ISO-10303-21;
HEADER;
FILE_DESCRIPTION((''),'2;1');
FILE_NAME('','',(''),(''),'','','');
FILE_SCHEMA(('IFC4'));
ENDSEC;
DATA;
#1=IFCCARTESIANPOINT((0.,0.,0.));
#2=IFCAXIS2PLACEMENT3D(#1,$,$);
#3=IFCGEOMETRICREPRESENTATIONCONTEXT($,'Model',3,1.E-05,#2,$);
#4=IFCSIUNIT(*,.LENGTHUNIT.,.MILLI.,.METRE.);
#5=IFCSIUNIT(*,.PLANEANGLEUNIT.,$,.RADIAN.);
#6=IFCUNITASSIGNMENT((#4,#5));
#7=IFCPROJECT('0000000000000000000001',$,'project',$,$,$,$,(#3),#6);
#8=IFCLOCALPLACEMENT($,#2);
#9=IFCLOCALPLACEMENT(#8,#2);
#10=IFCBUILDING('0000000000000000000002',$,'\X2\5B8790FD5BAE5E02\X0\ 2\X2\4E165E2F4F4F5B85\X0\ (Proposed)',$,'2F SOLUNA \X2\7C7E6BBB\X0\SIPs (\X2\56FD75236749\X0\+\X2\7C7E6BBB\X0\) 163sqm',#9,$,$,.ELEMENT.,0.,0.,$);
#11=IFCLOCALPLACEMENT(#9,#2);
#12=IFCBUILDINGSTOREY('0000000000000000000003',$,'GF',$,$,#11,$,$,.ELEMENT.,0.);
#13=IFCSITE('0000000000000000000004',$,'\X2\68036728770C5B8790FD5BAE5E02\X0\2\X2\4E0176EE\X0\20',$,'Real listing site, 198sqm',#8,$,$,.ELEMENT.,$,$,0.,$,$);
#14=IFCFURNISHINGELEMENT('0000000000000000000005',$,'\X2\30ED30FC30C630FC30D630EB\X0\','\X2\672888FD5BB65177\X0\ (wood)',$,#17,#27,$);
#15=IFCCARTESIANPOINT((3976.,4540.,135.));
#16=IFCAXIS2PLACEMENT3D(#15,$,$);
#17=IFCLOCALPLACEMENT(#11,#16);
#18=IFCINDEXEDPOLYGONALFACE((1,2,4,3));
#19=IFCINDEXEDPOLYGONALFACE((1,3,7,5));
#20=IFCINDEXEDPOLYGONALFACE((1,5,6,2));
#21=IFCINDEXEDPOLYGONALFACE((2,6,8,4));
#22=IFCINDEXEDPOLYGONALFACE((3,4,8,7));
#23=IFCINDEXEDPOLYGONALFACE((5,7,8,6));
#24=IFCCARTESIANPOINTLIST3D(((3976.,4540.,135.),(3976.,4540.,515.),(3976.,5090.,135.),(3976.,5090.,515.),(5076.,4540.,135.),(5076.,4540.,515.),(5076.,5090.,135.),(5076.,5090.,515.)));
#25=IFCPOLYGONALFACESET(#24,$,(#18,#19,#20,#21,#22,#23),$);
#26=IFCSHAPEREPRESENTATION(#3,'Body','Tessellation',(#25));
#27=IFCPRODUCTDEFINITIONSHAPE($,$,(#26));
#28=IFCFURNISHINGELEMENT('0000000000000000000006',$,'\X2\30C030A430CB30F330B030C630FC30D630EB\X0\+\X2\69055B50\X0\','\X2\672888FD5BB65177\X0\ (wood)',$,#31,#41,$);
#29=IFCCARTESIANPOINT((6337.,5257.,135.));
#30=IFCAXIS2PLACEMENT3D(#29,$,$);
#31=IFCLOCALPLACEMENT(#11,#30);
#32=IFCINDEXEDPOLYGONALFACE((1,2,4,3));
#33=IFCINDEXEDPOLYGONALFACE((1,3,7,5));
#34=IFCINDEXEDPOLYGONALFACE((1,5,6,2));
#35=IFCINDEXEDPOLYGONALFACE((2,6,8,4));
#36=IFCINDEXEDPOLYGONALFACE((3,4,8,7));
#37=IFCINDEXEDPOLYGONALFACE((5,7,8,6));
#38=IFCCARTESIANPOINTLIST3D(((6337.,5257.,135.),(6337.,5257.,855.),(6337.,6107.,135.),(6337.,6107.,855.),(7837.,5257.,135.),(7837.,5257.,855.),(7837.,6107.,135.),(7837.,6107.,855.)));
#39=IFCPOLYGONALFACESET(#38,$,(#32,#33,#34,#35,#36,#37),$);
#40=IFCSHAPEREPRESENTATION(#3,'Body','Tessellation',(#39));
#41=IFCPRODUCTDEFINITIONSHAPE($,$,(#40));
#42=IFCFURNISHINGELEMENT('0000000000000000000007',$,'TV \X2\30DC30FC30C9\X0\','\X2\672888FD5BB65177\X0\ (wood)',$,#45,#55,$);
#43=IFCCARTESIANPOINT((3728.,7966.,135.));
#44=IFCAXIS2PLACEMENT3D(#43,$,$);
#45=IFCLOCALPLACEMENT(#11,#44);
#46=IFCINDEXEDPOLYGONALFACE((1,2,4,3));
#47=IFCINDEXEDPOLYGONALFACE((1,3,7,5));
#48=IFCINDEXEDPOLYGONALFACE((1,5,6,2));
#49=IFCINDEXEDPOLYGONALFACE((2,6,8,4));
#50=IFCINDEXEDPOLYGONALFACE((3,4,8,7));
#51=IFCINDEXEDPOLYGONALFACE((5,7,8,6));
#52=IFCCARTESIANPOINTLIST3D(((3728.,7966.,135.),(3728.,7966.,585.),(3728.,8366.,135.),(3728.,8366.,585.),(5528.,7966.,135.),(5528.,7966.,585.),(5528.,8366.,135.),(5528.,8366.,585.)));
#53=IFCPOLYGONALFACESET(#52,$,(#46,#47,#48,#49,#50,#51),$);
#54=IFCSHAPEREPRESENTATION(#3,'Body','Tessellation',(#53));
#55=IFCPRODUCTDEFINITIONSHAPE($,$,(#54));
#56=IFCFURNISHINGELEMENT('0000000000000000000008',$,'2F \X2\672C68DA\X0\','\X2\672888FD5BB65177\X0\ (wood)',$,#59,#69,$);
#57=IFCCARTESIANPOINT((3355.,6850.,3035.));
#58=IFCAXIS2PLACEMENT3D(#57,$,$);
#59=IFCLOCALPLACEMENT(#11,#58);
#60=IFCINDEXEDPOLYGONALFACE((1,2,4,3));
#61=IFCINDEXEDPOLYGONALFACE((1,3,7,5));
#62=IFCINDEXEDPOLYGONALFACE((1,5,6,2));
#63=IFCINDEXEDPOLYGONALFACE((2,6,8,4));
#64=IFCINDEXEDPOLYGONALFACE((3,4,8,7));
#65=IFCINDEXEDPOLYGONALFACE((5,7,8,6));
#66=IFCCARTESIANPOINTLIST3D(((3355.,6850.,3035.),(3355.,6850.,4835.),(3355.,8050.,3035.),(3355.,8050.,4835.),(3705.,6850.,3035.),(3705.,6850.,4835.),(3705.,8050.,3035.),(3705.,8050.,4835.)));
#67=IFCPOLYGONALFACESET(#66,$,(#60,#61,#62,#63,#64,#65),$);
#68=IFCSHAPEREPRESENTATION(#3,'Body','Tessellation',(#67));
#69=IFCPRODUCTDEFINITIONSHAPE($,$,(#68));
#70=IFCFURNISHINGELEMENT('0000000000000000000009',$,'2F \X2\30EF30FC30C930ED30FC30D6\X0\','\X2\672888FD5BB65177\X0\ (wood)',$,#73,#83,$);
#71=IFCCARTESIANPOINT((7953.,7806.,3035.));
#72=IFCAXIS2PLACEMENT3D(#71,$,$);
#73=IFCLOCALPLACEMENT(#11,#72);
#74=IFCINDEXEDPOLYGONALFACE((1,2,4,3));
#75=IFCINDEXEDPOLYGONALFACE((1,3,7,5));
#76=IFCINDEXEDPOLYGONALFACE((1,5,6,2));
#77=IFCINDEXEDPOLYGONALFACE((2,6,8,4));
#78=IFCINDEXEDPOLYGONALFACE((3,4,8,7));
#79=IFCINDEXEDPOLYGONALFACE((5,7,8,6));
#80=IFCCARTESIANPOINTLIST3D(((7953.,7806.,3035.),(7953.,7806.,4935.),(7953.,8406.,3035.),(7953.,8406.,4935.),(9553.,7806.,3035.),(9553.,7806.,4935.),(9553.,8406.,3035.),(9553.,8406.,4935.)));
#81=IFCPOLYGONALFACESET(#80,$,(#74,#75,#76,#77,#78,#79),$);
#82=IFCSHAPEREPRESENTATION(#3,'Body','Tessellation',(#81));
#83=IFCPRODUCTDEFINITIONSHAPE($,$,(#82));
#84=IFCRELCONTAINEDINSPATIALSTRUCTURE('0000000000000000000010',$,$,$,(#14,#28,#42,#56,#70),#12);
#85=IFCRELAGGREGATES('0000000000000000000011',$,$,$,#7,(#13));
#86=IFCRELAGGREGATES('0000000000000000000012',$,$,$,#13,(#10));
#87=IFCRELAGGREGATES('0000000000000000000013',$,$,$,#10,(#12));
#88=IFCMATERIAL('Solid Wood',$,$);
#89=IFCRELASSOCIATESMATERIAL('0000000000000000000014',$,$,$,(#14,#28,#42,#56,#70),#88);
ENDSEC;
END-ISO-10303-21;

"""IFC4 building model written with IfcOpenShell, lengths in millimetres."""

from ifc_helpers import new_model, si_unit, frame, frame_2d, origin, place, context, project, spatial, rectangle, extrude, material, element, save


model = new_model("IFC4")

# Units and contexts
model_context = context("Model", 3, precision=1e-05, world=origin())
ifc_project = project(units=[si_unit("LENGTHUNIT", "METRE", prefix="MILLI"), si_unit("PLANEANGLEUNIT", "RADIAN")], contexts=[model_context])

# Site, building, storey
site_placement = place(None, origin())
site = spatial("IfcSite", under=ifc_project, at=site_placement, Name="栃木県宇都宮市2丁目20", ObjectType="Real listing site, 198sqm", CompositionType="ELEMENT", RefElevation=0.0)
building_placement = place(site_placement, origin())
building = spatial("IfcBuilding", under=site, at=building_placement, Name="宇都宮市 2世帯住宅 (Proposed)", ObjectType="2F SOLUNA 籾殻SIPs (国産杉+籾殻) 163sqm", CompositionType="ELEMENT", ElevationOfRefHeight=0.0, ElevationOfTerrain=0.0)
storey_placement = place(building_placement, origin())
storey = spatial("IfcBuildingStorey", under=building, at=storey_placement, Name="GF", CompositionType="ELEMENT", Elevation=0.0)

# Shared definitions
ifc_material_1 = material(Name="Solid Wood")

# Furnishing elements
furnishing_1_placement = place(storey_placement, frame((3976.0, 4540.0, 135.0)))
element("IfcFurnishingElement", 1, at=furnishing_1_placement, inside=storey, material=ifc_material_1, Name="ローテーブル", Description="木製家具 (wood)", context=model_context, shape_type="SweptSolid", body=[
    extrude(rectangle(XDim=1100.0, YDim=550.0, at=frame_2d((550.0, 275.0))), frame((3976.0, 4540.0, 135.0)), (0.0, 0.0, 1.0), 380.0),
])
furnishing_2_placement = place(storey_placement, frame((6337.0, 5257.0, 135.0)))
element("IfcFurnishingElement", 2, at=furnishing_2_placement, inside=storey, material=ifc_material_1, Name="ダイニングテーブル+椅子", Description="木製家具 (wood)", context=model_context, shape_type="SweptSolid", body=[
    extrude(rectangle(XDim=1500.0, YDim=850.0, at=frame_2d((750.0, 425.0))), frame((6337.0, 5257.0, 135.0)), (0.0, 0.0, 1.0), 720.0),
])
furnishing_3_placement = place(storey_placement, frame((3728.0, 7966.0, 135.0)))
element("IfcFurnishingElement", 3, at=furnishing_3_placement, inside=storey, material=ifc_material_1, Name="TV ボード", Description="木製家具 (wood)", context=model_context, shape_type="SweptSolid", body=[
    extrude(rectangle(XDim=1800.0, YDim=400.0, at=frame_2d((900.0, 200.0))), frame((3728.0, 7966.0, 135.0)), (0.0, 0.0, 1.0), 450.0),
])
furnishing_4_placement = place(storey_placement, frame((3355.0, 6850.0, 3035.0)))
element("IfcFurnishingElement", 4, at=furnishing_4_placement, inside=storey, material=ifc_material_1, Name="2F 本棚", Description="木製家具 (wood)", context=model_context, shape_type="SweptSolid", body=[
    extrude(rectangle(XDim=350.0, YDim=1200.0, at=frame_2d((175.0, 600.0))), frame((3355.0, 6850.0, 3035.0)), (0.0, 0.0, 1.0), 1800.0),
])
furnishing_5_placement = place(storey_placement, frame((7953.0, 7806.0, 3035.0)))
element("IfcFurnishingElement", 5, at=furnishing_5_placement, inside=storey, material=ifc_material_1, Name="2F ワードローブ", Description="木製家具 (wood)", context=model_context, shape_type="SweptSolid", body=[
    extrude(rectangle(XDim=1600.0, YDim=600.0, at=frame_2d((800.0, 300.0))), frame((7953.0, 7806.0, 3035.0)), (0.0, 0.0, 1.0), 1900.0),
])

save(model, "model.ifc")
